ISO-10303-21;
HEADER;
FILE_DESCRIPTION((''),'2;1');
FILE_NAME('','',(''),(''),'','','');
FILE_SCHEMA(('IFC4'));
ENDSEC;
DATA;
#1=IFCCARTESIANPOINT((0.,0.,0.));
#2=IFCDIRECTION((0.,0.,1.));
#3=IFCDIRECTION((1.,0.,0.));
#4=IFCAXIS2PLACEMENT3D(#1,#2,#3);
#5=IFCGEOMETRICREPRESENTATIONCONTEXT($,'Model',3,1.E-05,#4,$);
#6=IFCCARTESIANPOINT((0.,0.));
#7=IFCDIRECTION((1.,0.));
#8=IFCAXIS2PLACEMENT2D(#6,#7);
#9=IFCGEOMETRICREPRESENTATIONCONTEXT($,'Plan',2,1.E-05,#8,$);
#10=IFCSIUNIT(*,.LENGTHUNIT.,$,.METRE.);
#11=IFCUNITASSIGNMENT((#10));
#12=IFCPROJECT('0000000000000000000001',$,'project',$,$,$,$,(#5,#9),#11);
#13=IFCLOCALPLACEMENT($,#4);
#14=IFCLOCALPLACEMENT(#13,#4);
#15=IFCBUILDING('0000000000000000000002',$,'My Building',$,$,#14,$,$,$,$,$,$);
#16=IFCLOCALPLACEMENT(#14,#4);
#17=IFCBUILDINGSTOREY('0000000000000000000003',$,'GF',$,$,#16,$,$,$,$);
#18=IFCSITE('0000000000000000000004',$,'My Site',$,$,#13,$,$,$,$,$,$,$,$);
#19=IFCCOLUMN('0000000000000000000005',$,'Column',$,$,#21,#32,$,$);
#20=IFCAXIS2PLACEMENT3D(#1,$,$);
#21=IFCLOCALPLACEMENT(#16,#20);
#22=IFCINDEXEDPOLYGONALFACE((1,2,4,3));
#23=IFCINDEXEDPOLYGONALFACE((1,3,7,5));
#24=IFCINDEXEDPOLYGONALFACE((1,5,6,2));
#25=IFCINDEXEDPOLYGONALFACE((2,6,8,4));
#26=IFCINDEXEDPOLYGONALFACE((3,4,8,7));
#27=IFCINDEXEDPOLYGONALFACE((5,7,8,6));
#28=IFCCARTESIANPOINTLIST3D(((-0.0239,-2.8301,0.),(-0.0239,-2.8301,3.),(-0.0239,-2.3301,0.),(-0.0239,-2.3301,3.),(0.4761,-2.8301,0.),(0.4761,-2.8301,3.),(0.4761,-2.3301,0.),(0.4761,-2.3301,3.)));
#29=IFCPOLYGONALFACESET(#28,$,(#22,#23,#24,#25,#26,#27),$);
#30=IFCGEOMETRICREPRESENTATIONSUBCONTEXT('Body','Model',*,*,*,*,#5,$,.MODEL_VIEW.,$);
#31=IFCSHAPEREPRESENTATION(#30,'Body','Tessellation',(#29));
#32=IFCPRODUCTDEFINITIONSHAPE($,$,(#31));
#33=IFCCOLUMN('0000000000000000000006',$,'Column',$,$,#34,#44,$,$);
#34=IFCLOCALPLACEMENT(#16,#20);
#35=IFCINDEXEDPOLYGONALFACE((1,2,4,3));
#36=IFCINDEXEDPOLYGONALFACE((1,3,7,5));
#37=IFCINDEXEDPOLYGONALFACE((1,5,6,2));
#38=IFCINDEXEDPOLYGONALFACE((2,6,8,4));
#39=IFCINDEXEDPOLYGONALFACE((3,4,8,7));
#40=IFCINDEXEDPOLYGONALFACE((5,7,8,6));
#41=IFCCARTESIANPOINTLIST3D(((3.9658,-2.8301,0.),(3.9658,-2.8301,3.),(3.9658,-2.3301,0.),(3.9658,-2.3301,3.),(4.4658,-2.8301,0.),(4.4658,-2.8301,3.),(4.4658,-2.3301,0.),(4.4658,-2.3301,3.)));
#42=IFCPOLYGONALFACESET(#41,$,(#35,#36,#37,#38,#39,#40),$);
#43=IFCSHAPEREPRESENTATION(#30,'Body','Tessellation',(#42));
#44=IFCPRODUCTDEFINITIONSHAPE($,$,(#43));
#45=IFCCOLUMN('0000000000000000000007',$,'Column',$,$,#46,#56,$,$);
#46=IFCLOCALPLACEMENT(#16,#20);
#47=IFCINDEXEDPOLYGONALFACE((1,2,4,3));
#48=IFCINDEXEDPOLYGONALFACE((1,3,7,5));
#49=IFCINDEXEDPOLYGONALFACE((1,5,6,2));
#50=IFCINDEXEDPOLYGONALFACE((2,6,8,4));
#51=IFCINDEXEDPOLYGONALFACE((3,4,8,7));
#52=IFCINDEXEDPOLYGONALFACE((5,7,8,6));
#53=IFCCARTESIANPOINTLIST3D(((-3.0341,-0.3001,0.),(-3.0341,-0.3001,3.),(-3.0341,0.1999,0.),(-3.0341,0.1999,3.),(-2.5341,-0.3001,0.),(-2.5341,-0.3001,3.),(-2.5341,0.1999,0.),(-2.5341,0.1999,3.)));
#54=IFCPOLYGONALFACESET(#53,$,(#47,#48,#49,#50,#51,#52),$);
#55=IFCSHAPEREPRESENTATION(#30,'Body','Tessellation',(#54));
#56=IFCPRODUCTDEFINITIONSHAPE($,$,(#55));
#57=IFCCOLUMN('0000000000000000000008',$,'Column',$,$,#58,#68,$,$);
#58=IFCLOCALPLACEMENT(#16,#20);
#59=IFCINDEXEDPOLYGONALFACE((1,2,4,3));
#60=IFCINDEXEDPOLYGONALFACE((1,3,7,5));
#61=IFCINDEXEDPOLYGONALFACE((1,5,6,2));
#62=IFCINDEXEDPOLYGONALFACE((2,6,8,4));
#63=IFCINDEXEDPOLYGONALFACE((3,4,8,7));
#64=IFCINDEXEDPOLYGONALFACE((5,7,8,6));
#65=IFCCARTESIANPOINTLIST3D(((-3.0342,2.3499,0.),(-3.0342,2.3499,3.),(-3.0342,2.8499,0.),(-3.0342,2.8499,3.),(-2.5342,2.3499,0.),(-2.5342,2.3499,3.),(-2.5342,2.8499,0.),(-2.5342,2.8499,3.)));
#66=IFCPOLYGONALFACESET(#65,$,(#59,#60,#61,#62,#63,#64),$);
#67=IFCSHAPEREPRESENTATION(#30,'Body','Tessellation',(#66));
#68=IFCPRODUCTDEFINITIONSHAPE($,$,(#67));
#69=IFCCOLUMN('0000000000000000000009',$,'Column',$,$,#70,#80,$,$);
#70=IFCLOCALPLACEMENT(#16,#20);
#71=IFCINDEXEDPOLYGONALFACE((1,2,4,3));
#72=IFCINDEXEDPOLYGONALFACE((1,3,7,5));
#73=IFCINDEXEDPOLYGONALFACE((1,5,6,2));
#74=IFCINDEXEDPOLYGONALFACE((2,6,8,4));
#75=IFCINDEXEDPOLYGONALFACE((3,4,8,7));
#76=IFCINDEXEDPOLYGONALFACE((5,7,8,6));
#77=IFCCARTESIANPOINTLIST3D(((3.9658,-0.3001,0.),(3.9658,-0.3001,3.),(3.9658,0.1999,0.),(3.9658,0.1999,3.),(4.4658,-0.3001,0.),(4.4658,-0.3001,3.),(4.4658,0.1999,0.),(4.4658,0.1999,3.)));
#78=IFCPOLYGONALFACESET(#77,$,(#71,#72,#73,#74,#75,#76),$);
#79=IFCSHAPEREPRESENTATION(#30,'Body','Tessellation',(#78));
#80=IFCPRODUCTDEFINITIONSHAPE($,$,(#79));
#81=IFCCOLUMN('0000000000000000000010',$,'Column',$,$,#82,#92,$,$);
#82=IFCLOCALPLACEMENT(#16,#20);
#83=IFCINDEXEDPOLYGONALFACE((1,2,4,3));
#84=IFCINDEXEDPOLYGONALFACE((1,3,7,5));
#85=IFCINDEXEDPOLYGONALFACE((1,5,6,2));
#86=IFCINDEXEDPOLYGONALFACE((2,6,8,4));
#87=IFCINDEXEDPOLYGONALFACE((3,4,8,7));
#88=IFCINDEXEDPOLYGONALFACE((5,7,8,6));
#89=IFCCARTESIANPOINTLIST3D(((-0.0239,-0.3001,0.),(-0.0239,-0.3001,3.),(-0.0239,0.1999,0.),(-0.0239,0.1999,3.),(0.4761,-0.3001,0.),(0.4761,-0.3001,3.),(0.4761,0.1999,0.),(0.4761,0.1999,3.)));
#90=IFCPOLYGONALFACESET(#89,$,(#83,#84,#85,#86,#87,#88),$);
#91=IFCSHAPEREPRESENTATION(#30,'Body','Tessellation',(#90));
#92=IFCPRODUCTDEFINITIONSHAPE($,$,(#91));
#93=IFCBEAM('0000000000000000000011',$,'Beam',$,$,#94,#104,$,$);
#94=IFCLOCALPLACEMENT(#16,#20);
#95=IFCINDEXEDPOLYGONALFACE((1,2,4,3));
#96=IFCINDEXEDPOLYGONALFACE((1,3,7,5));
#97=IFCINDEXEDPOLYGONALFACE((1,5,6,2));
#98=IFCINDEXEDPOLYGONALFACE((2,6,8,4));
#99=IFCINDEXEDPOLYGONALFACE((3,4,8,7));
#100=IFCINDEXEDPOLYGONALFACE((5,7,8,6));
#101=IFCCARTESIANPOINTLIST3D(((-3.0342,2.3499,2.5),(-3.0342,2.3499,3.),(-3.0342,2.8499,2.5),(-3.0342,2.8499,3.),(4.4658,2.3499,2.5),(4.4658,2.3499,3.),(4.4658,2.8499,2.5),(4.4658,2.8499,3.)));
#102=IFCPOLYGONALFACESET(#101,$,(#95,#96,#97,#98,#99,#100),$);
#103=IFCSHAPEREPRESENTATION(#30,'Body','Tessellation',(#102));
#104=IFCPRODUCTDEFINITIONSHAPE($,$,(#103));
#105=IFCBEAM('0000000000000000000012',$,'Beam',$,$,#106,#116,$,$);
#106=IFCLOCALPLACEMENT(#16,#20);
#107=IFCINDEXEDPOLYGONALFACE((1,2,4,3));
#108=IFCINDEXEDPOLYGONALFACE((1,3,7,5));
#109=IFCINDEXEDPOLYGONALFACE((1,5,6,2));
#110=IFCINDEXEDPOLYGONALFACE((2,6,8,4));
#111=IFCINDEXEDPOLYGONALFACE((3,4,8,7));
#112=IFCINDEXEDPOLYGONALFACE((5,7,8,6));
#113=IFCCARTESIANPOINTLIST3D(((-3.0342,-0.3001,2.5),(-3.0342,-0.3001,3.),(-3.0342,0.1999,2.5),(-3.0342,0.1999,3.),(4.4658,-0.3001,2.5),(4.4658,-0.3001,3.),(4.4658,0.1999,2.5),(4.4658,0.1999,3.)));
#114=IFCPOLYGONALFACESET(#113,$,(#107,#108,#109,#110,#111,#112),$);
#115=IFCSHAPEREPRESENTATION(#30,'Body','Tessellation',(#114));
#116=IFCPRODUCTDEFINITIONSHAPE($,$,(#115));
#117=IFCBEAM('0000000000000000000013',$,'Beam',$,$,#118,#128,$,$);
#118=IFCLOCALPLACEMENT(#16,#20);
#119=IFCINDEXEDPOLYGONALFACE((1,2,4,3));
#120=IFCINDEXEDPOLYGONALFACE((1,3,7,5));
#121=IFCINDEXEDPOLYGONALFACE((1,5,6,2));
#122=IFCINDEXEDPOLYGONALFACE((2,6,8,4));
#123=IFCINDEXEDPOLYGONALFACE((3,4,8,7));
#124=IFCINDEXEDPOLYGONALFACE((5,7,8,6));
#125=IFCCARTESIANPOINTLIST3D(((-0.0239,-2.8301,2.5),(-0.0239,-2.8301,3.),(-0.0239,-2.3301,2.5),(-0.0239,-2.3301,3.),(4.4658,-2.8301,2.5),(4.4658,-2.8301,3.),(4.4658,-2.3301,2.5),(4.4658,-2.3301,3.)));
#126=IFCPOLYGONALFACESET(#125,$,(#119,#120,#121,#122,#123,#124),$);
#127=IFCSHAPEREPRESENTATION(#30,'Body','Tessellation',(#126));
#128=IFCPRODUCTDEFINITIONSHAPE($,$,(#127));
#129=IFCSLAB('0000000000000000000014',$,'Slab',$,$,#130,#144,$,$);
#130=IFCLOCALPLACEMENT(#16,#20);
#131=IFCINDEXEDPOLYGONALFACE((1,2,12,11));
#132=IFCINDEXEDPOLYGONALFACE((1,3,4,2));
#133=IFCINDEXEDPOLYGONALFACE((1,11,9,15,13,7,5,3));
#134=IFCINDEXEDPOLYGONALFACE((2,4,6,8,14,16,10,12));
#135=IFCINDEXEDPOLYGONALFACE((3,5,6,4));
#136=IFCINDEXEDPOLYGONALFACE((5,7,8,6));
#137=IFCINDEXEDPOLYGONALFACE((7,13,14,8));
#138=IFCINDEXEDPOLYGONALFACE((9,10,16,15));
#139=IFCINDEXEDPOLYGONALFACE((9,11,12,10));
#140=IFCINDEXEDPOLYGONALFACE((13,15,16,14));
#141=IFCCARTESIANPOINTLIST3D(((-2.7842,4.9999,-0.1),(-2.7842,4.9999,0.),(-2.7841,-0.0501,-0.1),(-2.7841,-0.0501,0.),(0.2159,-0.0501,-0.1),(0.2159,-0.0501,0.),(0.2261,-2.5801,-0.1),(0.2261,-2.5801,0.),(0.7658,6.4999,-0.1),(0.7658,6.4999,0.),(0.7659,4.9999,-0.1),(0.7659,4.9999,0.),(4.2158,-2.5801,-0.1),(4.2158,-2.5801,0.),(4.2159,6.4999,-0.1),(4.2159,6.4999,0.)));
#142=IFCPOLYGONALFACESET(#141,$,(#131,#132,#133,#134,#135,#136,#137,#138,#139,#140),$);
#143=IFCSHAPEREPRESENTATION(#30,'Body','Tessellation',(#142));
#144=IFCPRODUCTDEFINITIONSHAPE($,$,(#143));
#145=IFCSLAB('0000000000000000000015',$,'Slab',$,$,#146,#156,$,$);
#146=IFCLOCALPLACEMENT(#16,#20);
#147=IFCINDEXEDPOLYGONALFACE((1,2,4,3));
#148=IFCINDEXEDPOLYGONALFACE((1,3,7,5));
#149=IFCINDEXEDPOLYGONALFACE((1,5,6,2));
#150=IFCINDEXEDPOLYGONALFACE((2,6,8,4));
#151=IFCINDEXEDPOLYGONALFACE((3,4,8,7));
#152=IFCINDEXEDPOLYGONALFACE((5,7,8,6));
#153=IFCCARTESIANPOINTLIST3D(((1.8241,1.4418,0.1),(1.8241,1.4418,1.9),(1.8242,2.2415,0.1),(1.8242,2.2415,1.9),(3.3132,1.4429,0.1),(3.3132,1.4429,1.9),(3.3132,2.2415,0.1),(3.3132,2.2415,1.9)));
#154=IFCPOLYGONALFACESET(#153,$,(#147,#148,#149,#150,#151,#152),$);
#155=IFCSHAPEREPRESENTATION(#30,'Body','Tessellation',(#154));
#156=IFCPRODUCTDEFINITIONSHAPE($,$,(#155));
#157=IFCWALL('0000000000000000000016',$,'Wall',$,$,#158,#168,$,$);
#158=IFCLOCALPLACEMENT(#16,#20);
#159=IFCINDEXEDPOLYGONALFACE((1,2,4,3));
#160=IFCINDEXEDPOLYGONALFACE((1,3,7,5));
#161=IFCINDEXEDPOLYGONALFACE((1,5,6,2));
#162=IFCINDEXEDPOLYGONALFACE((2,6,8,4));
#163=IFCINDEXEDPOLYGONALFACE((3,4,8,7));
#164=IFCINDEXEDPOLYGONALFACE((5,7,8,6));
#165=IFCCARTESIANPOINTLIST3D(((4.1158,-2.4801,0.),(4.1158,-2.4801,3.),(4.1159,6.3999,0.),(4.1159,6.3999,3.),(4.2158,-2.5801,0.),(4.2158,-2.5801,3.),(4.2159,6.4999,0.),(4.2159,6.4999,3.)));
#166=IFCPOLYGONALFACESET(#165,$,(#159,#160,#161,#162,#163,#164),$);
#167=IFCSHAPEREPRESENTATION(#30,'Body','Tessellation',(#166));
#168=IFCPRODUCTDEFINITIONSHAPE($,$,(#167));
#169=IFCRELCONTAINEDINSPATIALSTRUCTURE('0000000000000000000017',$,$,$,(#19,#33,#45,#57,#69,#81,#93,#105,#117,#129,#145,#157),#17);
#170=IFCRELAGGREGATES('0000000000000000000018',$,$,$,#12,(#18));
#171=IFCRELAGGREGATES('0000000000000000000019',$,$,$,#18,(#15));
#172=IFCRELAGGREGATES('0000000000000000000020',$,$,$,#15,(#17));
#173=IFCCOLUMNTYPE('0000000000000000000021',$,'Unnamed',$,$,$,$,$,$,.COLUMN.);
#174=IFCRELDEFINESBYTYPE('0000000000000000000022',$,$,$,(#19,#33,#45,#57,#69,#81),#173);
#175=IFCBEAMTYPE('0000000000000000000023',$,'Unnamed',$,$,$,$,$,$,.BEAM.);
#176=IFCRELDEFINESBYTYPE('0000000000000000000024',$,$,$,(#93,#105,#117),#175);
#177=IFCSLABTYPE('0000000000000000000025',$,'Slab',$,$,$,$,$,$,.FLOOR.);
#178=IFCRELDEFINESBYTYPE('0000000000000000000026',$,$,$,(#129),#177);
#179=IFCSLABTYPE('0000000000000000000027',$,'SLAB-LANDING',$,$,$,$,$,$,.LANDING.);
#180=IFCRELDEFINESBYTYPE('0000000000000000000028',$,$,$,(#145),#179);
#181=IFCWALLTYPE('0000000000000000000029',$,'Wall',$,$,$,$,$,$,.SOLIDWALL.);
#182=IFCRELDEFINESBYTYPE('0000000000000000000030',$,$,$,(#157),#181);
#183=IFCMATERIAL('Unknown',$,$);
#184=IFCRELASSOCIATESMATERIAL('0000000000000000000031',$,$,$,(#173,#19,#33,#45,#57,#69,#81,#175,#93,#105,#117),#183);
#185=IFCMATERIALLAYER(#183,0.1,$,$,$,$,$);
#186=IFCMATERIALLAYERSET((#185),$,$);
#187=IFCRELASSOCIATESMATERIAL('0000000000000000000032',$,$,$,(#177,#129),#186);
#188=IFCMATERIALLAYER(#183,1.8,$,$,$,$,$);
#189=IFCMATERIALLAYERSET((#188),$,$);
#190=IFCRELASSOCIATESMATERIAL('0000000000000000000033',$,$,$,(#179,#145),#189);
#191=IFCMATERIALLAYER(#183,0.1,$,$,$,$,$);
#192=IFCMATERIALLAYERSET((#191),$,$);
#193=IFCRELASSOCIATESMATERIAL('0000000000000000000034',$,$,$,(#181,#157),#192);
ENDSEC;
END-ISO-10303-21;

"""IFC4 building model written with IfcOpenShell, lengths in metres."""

from ifc_helpers import new_model, si_unit, frame, origin_with_axes, origin_2d_with_axis, place, context, subcontext, project, spatial, line, indexed_curve, rectangle, outline, extrude, material, layer, layer_set, layer_usage, material_profile, profile_set, profile_usage, type_object, element, save


model = new_model("IFC4")

# Units and contexts
model_context = context("Model", 3, precision=1e-05, world=origin_with_axes())
plan_context = context("Plan", 2, precision=1e-05, world=origin_2d_with_axis())
body_context_1 = subcontext(model_context, "Body", "Model", "MODEL_VIEW")
ifc_project = project(units=[si_unit("LENGTHUNIT", "METRE")], contexts=[model_context, plan_context])

# Site, building, storey
site_placement = place(None, origin_with_axes())
site = spatial("IfcSite", under=ifc_project, at=site_placement, Name="My Site")
building_placement = place(site_placement, origin_with_axes())
building = spatial("IfcBuilding", under=site, at=building_placement, Name="My Building")
storey_placement = place(building_placement, origin_with_axes())
storey = spatial("IfcBuildingStorey", under=building, at=storey_placement, Name="GF")

# Columns
ifc_material = material(Name="Unknown")
ifc_material_profile_1 = material_profile(ifc_material, rectangle(XDim=0.5, YDim=0.5))
ifc_profile_set_1 = profile_set([ifc_material_profile_1])
ifc_profile_usage_1 = profile_usage(ifc_profile_set_1, cardinal=5)
column_type = type_object("IfcColumnType", Name="Unnamed", PredefinedType="COLUMN", material=ifc_profile_set_1)
column_1_placement = place(storey_placement, frame((0.2261, -2.5801, 0.0), z_axis=(0.0, 0.0, 1.0), x_axis=(1.0, 0.0, 0.0)))
element("IfcColumn", 1, at=column_1_placement, inside=storey, type_object=column_type, material=ifc_profile_usage_1, Name="Column", context=body_context_1, shape_type="SweptSolid", body=[
    extrude(rectangle(XDim=0.5, YDim=0.5), origin_with_axes(), (0.0, 0.0, 1.0), 3.0),
])
ifc_profile_usage_2 = profile_usage(ifc_profile_set_1, cardinal=5)
column_2_placement = place(storey_placement, frame((4.2158, -2.5801, 0.0), z_axis=(0.0, 0.0, 1.0), x_axis=(1.0, 0.0, 0.0)))
element("IfcColumn", 2, at=column_2_placement, inside=storey, type_object=column_type, material=ifc_profile_usage_2, Name="Column", context=body_context_1, shape_type="SweptSolid", body=[
    extrude(rectangle(XDim=0.5, YDim=0.5), origin_with_axes(), (0.0, 0.0, 1.0), 3.0),
])
ifc_profile_usage_3 = profile_usage(ifc_profile_set_1, cardinal=5)
column_3_placement = place(storey_placement, frame((-2.7841, -0.0501, 0.0), z_axis=(0.0, 0.0, 1.0), x_axis=(1.0, 0.0, 0.0)))
element("IfcColumn", 3, at=column_3_placement, inside=storey, type_object=column_type, material=ifc_profile_usage_3, Name="Column", context=body_context_1, shape_type="SweptSolid", body=[
    extrude(rectangle(XDim=0.5, YDim=0.5), origin_with_axes(), (0.0, 0.0, 1.0), 3.0),
])
ifc_profile_usage_4 = profile_usage(ifc_profile_set_1, cardinal=5)
column_4_placement = place(storey_placement, frame((-2.7842, 2.5999, 0.0), z_axis=(0.0, 0.0, 1.0), x_axis=(1.0, 0.0, 0.0)))
element("IfcColumn", 4, at=column_4_placement, inside=storey, type_object=column_type, material=ifc_profile_usage_4, Name="Column", context=body_context_1, shape_type="SweptSolid", body=[
    extrude(rectangle(XDim=0.5, YDim=0.5), origin_with_axes(), (0.0, 0.0, 1.0), 3.0),
])
ifc_profile_usage_5 = profile_usage(ifc_profile_set_1, cardinal=5)
column_5_placement = place(storey_placement, frame((4.2158, -0.0501, 0.0), z_axis=(0.0, 0.0, 1.0), x_axis=(1.0, 0.0, 0.0)))
element("IfcColumn", 5, at=column_5_placement, inside=storey, type_object=column_type, material=ifc_profile_usage_5, Name="Column", context=body_context_1, shape_type="SweptSolid", body=[
    extrude(rectangle(XDim=0.5, YDim=0.5), origin_with_axes(), (0.0, 0.0, 1.0), 3.0),
])
ifc_profile_usage_6 = profile_usage(ifc_profile_set_1, cardinal=5)
column_6_placement = place(storey_placement, frame((0.2261, -0.0501, 0.0), z_axis=(0.0, 0.0, 1.0), x_axis=(1.0, 0.0, 0.0)))
element("IfcColumn", 6, at=column_6_placement, inside=storey, type_object=column_type, material=ifc_profile_usage_6, Name="Column", context=body_context_1, shape_type="SweptSolid", body=[
    extrude(rectangle(XDim=0.5, YDim=0.5), origin_with_axes(), (0.0, 0.0, 1.0), 3.0),
])

# Beams
ifc_material_profile_2 = material_profile(ifc_material, rectangle(XDim=0.5, YDim=0.5))
ifc_profile_set_2 = profile_set([ifc_material_profile_2])
ifc_profile_usage_7 = profile_usage(ifc_profile_set_2, cardinal=7)
beam_type = type_object("IfcBeamType", Name="Unnamed", PredefinedType="BEAM", material=ifc_profile_set_2)
beam_1_placement = place(storey_placement, frame((4.4658, 2.3499, 3.0), z_axis=(-1.0, 0.0, 0.0), x_axis=(0.0, -1.0, 0.0)))
element("IfcBeam", 7, at=beam_1_placement, inside=storey, type_object=beam_type, material=ifc_profile_usage_7, Name="Beam", context=body_context_1, shape_type="SweptSolid", body=[
    extrude(rectangle(XDim=0.5, YDim=0.5), frame((-0.25, -0.25, 0.0), z_axis=(0.0, 0.0, 1.0), x_axis=(1.0, 0.0, 0.0)), (0.0, 0.0, 1.0), 7.5),
])
ifc_profile_usage_8 = profile_usage(ifc_profile_set_2, cardinal=7)
beam_2_placement = place(storey_placement, frame((4.4658, -0.3001, 3.0), z_axis=(-1.0, 0.0, 0.0), x_axis=(0.0, -1.0, 0.0)))
element("IfcBeam", 8, at=beam_2_placement, inside=storey, type_object=beam_type, material=ifc_profile_usage_8, Name="Beam", context=body_context_1, shape_type="SweptSolid", body=[
    extrude(rectangle(XDim=0.5, YDim=0.5), frame((-0.25, -0.25, 0.0), z_axis=(0.0, 0.0, 1.0), x_axis=(1.0, 0.0, 0.0)), (0.0, 0.0, 1.0), 7.5),
])
ifc_profile_usage_9 = profile_usage(ifc_profile_set_2, cardinal=7)
beam_3_placement = place(storey_placement, frame((4.4658, -2.8301, 3.0), z_axis=(-1.0, -0.000001, 0.0), x_axis=(0.000001, -1.0, 0.0)))
element("IfcBeam", 9, at=beam_3_placement, inside=storey, type_object=beam_type, material=ifc_profile_usage_9, Name="Beam", context=body_context_1, shape_type="SweptSolid", body=[
    extrude(rectangle(XDim=0.5, YDim=0.5), frame((-0.25, -0.25, 0.0), z_axis=(0.0, 0.0, 1.0), x_axis=(1.0, 0.0, 0.0)), (0.0, 0.0, 1.0), 4.4897),
])

# Slabs
ifc_layer_1 = layer(ifc_material, 0.1)
ifc_layer_set_1 = layer_set([ifc_layer_1])
ifc_layer_usage_1 = layer_usage(ifc_layer_set_1, "AXIS3", "POSITIVE", -0.1)
slab_type_1 = type_object("IfcSlabType", Name="Slab", PredefinedType="FLOOR", material=ifc_layer_set_1)
slab_1_placement = place(storey_placement, frame((0.2261, -2.5801, 0.0), z_axis=(0.0, 0.0, 1.0), x_axis=(1.0, 0.0, 0.0)))
element("IfcSlab", 10, at=slab_1_placement, inside=storey, type_object=slab_type_1, material=ifc_layer_usage_1, Name="Slab", context=body_context_1, shape_type="SweptSolid", body=[
    extrude(outline(indexed_curve([(0.0, 0.0), (3.9897, 0.0), (3.9897, 9.08), (0.5397, 9.08), (0.5397, 7.58), (-3.0103, 7.58), (-3.0103, 2.53), (-0.0103, 2.53), (0.0, 0.0)])), frame((0.0, 0.0, -0.1), z_axis=(0.0, 0.0, 1.0), x_axis=(1.0, 0.0, 0.0)), (0.0, 0.0, 1.0), 0.1),
])
ifc_layer_2 = layer(ifc_material, 1.8)
ifc_layer_set_2 = layer_set([ifc_layer_2])
slab_type_2 = type_object("IfcSlabType", Name="SLAB-LANDING", PredefinedType="LANDING", material=ifc_layer_set_2)
ifc_layer_usage_2 = layer_usage(ifc_layer_set_2, "AXIS3", "POSITIVE", -1.8)
slab_2_placement = place(storey_placement, frame((1.8241, 1.4418, 1.9), z_axis=(0.0, 0.0, 1.0), x_axis=(1.0, 0.0, 0.0)))
element("IfcSlab", 11, at=slab_2_placement, inside=storey, type_object=slab_type_2, material=ifc_layer_usage_2, Name="Slab", context=body_context_1, shape_type="SweptSolid", body=[
    extrude(outline(indexed_curve([(0.0, 0.0), (1.489, 0.0011), (1.489, 0.7997), (0.0, 0.7997), (0.0, 0.0)])), frame((0.0, 0.0, -1.8), z_axis=(0.0, 0.0, 1.0), x_axis=(1.0, 0.0, 0.0)), (0.0, 0.0, 1.0), 1.8),
])

# Shared definitions
ifc_layer_3 = layer(ifc_material, 0.1)
ifc_layer_set_3 = layer_set([ifc_layer_3])
wall_type = type_object("IfcWallType", Name="Wall", PredefinedType="SOLIDWALL", material=ifc_layer_set_3)

# Wall
ifc_layer_usage_3 = layer_usage(ifc_layer_set_3, "AXIS2", "POSITIVE", 0.0)
wall_1_placement = place(storey_placement, frame((4.2158, -2.5801, 0.0), z_axis=(0.0, 0.0, 1.0), x_axis=(0.0, 1.0, 0.0)))
element("IfcWall", 12, at=wall_1_placement, inside=storey, type_object=wall_type, material=ifc_layer_usage_3, Name="Wall", context=body_context_1, shape_type="SweptSolid", body=[
    extrude(outline(indexed_curve([(0.0, 0.0), (0.1, 0.1), (8.98, 0.1), (9.08, 0.0)], segments=[line(1, 2, 3, 4, 1)])), origin_with_axes(), (0.0, 0.0, 1.0), 3.0),
])

save(model, "model.ifc")
